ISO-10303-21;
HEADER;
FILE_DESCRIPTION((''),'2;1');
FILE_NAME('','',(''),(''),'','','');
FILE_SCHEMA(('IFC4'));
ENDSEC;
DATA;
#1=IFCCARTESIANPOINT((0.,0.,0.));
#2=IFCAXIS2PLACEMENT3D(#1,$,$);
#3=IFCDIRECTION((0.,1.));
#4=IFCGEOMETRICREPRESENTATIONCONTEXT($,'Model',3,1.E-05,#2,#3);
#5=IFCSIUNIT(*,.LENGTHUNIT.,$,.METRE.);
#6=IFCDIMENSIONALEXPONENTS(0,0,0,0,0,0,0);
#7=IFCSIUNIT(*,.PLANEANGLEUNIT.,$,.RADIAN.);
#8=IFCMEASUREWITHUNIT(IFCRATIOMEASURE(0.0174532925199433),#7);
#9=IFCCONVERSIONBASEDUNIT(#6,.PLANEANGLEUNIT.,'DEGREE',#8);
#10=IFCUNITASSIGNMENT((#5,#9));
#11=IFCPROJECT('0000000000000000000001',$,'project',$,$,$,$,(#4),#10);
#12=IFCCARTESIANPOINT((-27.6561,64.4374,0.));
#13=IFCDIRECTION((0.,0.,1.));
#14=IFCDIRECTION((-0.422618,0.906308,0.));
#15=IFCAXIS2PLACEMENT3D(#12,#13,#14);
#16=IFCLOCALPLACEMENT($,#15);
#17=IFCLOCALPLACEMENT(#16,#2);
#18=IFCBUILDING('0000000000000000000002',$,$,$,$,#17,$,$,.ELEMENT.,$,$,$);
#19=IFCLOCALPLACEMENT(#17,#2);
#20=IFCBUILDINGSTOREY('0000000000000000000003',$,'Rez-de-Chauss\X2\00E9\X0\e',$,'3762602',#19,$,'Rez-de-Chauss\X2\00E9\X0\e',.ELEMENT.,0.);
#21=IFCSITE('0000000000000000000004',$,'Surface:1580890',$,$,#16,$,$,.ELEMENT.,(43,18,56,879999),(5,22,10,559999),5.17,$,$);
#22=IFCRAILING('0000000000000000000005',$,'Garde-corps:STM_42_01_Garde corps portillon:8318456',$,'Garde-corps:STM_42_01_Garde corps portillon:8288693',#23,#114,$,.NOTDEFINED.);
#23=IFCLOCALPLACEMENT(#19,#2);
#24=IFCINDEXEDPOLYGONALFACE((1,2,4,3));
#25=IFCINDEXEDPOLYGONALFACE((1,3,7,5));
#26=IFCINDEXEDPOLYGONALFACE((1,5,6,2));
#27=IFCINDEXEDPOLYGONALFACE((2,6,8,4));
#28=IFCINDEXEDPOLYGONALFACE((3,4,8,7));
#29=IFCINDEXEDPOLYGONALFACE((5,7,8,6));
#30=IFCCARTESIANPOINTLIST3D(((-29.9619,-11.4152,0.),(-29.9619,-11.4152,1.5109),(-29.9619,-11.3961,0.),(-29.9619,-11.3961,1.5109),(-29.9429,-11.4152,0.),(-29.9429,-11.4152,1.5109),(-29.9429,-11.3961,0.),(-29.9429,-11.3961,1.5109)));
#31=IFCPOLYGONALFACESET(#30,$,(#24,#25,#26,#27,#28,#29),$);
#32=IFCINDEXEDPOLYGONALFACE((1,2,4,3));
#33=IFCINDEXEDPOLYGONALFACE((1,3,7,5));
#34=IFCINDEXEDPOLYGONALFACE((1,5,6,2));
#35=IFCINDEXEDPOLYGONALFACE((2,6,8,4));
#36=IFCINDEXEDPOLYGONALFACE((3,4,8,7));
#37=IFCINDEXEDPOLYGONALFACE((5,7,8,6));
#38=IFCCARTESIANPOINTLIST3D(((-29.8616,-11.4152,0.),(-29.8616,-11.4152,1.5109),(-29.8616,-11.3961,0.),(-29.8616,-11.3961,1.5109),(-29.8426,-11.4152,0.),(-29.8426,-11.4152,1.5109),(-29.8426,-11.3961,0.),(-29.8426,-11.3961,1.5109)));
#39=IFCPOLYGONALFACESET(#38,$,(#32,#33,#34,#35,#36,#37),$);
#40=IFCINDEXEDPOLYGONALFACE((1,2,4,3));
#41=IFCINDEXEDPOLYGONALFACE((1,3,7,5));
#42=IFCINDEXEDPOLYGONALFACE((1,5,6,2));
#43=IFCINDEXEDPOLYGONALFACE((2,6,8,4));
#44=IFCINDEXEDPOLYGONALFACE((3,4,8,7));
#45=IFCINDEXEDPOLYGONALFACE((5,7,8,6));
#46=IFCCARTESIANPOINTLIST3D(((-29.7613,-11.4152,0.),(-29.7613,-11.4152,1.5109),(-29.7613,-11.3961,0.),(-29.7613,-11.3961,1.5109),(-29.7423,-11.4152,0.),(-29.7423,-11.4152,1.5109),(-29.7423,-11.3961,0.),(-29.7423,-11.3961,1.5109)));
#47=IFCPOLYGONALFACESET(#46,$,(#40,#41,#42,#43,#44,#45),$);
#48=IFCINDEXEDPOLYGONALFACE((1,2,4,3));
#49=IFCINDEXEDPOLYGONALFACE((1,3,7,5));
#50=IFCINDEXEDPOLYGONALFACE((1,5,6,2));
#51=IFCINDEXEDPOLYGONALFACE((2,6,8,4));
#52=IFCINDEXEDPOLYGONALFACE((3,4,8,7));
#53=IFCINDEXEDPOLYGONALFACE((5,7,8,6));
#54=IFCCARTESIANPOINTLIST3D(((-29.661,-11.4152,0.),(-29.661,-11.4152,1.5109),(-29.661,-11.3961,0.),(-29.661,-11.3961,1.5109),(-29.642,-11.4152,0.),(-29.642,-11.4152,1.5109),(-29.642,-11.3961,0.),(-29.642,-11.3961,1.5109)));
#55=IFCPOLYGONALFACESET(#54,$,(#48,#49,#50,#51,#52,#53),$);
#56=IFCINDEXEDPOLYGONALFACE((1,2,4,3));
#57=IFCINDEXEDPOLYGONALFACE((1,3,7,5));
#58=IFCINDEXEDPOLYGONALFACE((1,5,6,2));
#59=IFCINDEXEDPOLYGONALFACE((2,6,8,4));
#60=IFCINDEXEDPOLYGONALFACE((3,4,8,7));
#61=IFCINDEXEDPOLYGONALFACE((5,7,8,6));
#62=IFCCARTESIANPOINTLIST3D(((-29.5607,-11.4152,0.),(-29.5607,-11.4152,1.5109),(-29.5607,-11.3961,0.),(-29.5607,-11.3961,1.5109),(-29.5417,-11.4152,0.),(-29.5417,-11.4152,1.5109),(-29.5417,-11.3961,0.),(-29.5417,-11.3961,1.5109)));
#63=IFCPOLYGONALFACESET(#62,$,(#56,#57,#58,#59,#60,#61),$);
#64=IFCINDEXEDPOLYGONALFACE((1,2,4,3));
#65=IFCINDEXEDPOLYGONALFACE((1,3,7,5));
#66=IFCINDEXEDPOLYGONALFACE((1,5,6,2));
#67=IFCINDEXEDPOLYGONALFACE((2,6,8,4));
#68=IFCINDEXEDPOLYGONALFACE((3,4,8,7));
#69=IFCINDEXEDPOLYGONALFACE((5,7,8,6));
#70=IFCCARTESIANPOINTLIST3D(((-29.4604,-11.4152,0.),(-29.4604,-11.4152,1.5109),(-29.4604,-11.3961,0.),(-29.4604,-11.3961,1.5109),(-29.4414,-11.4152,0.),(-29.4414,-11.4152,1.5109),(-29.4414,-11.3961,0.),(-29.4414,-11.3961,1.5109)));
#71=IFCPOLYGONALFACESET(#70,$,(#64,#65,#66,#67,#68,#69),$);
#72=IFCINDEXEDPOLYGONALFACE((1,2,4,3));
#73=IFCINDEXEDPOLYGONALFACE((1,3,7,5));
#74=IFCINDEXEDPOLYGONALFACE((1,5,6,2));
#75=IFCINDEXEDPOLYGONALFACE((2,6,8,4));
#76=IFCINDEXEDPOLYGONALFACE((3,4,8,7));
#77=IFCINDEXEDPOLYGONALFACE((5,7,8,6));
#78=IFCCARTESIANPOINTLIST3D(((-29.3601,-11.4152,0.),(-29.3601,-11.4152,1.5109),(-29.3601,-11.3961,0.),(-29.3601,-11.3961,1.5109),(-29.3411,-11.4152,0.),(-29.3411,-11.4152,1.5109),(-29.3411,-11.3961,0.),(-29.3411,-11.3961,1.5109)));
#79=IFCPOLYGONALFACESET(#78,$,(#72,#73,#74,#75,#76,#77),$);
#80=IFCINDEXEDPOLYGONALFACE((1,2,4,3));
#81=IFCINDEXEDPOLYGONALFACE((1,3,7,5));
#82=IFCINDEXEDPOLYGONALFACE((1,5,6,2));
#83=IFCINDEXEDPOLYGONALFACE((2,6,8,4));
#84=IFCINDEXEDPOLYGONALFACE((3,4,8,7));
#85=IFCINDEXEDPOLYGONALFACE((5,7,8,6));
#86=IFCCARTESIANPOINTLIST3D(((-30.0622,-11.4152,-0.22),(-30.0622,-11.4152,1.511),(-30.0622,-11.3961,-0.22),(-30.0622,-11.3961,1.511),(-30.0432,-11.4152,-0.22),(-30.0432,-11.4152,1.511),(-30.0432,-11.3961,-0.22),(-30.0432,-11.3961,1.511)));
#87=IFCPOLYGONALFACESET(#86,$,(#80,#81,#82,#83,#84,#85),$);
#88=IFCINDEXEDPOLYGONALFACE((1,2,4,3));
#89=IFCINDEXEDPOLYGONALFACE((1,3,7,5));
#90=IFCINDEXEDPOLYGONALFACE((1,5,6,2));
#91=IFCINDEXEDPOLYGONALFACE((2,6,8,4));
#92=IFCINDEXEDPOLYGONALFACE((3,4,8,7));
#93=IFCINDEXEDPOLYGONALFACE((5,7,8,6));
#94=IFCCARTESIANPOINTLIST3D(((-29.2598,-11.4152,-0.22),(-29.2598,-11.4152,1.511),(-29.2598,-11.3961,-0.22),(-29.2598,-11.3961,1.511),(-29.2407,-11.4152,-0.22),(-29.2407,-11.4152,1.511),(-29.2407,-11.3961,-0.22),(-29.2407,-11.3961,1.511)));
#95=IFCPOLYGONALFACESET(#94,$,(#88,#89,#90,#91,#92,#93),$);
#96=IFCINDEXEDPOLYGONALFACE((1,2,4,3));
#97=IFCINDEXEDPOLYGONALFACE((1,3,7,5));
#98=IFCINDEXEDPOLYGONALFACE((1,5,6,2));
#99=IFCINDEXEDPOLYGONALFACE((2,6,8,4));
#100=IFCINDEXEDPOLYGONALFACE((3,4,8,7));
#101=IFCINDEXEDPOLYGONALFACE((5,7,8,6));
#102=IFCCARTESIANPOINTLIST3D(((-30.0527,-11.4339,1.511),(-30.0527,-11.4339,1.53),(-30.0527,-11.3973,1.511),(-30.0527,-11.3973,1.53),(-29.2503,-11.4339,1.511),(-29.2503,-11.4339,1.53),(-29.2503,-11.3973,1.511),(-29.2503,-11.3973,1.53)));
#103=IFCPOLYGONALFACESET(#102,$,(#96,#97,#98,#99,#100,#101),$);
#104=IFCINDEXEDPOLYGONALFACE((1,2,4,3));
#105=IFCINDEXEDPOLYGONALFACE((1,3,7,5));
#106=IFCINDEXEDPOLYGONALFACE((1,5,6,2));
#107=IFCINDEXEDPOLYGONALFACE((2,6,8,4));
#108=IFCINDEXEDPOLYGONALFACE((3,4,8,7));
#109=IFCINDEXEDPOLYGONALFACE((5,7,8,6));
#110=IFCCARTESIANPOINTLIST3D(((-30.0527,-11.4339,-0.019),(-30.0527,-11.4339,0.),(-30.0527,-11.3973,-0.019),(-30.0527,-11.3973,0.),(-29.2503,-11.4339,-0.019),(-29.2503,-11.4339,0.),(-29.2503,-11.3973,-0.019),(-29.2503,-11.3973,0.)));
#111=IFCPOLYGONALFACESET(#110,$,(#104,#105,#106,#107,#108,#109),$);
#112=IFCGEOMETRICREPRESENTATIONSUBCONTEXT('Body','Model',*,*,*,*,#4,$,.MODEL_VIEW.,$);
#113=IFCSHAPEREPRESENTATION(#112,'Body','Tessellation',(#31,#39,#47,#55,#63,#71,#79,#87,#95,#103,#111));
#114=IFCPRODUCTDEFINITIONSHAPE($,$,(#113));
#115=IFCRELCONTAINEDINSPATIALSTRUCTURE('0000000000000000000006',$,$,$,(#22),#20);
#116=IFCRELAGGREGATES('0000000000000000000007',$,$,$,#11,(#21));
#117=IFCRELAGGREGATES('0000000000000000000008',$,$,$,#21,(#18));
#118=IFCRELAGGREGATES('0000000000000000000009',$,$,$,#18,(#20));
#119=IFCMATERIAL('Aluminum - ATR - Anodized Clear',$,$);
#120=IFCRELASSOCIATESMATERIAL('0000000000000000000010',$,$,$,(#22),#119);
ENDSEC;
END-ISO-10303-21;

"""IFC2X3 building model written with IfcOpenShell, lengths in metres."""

from ifc_helpers import new_model, entity, si_unit, converted_unit, direction, frame, frame_2d, origin, origin_2d_with_axis, place, context, subcontext, project, spatial, rectangle, extrude, material, element, save


model = new_model("IFC2X3")

# Units and contexts
model_context = context("Model", 3, precision=1e-05, world=origin(), true_north=direction((0.0, 1.0)))
body_context = subcontext(model_context, "Body", "Model", "MODEL_VIEW")
ifc_project = project(units=[si_unit("LENGTHUNIT", "METRE"), converted_unit("PLANEANGLEUNIT", "DEGREE", entity("IfcRatioMeasure", 0.0174532925199433), si_unit("PLANEANGLEUNIT", "RADIAN"), dimensions=[0, 0, 0, 0, 0, 0, 0])], contexts=[model_context])

# Site, building, storey
site_placement = place(None, frame((-27.6561, 64.4374, 0.0), z_axis=(0.0, 0.0, 1.0), x_axis=(-0.422618, 0.906308, 0.0)))
site = spatial("IfcSite", under=ifc_project, at=site_placement, Name="Surface:1580890", CompositionType="ELEMENT", RefLatitude=(43, 18, 56, 879999), RefLongitude=(5, 22, 10, 559999), RefElevation=5.17)
building_placement = place(site_placement, origin())
building = spatial("IfcBuilding", under=site, at=building_placement, CompositionType="ELEMENT")
storey_placement = place(building_placement, origin())
storey = spatial("IfcBuildingStorey", under=building, at=storey_placement, Name="Rez-de-Chaussée", ObjectType="3762602", LongName="Rez-de-Chaussée", CompositionType="ELEMENT", Elevation=0.0)

# Railing
ifc_material_1 = material(Name="Aluminum - ATR - Anodized Clear")
railing_1_placement = place(storey_placement, origin())
element("IfcRailing", 1, at=railing_1_placement, inside=storey, material=ifc_material_1, Name="Garde-corps:STM_42_01_Garde corps portillon:8318456", ObjectType="Garde-corps:STM_42_01_Garde corps portillon:8288693", PredefinedType="NOTDEFINED", context=body_context, shape_type="SweptSolid", body=[
    extrude(rectangle(XDim=0.0191, YDim=0.0191, at=origin_2d_with_axis()), frame((-29.9524, -11.4056, 0.0), z_axis=(0.0, 0.0, 1.0), x_axis=(-1.0, 0.0, 0.0)), (0.0, 0.0, 1.0), 1.5109),
    extrude(rectangle(XDim=0.0191, YDim=0.0191, at=origin_2d_with_axis()), frame((-29.8521, -11.4056, 0.0), z_axis=(0.0, 0.0, 1.0), x_axis=(-1.0, 0.0, 0.0)), (0.0, 0.0, 1.0), 1.5109),
    extrude(rectangle(XDim=0.0191, YDim=0.0191, at=origin_2d_with_axis()), frame((-29.7518, -11.4056, 0.0), z_axis=(0.0, 0.0, 1.0), x_axis=(-1.0, 0.0, 0.0)), (0.0, 0.0, 1.0), 1.5109),
    extrude(rectangle(XDim=0.0191, YDim=0.0191, at=origin_2d_with_axis()), frame((-29.6515, -11.4056, 0.0), z_axis=(0.0, 0.0, 1.0), x_axis=(-1.0, 0.0, 0.0)), (0.0, 0.0, 1.0), 1.5109),
    extrude(rectangle(XDim=0.0191, YDim=0.0191, at=origin_2d_with_axis()), frame((-29.5512, -11.4056, 0.0), z_axis=(0.0, 0.0, 1.0), x_axis=(-1.0, 0.0, 0.0)), (0.0, 0.0, 1.0), 1.5109),
    extrude(rectangle(XDim=0.0191, YDim=0.0191, at=origin_2d_with_axis()), frame((-29.4509, -11.4056, 0.0), z_axis=(0.0, 0.0, 1.0), x_axis=(-1.0, 0.0, 0.0)), (0.0, 0.0, 1.0), 1.5109),
    extrude(rectangle(XDim=0.0191, YDim=0.0191, at=origin_2d_with_axis()), frame((-29.3506, -11.4056, 0.0), z_axis=(0.0, 0.0, 1.0), x_axis=(-1.0, 0.0, 0.0)), (0.0, 0.0, 1.0), 1.5109),
    extrude(rectangle(XDim=0.0191, YDim=0.0191, at=origin_2d_with_axis()), frame((-30.0527, -11.4056, -0.22), z_axis=(0.0, 0.0, 1.0), x_axis=(-1.0, 0.0, 0.0)), (0.0, 0.0, 1.0), 1.7309),
    extrude(rectangle(XDim=0.0191, YDim=0.0191, at=origin_2d_with_axis()), frame((-29.2503, -11.4056, -0.22), z_axis=(0.0, 0.0, 1.0), x_axis=(-1.0, 0.0, 0.0)), (0.0, 0.0, 1.0), 1.7309),
    extrude(rectangle(XDim=0.8024, YDim=0.0366, at=frame_2d((0.0, 0.0), x_axis=(1.0, 0.0))), frame((-29.6515, -11.4156, 1.511), z_axis=(0.0, 0.0, 1.0), x_axis=(-1.0, 0.0, 0.0)), (0.0, 0.0, 1.0), 0.0191),
    extrude(rectangle(XDim=0.8024, YDim=0.0366, at=frame_2d((0.0, 0.0), x_axis=(1.0, 0.0))), frame((-29.6515, -11.4156, -0.019), z_axis=(0.0, 0.0, 1.0), x_axis=(-1.0, 0.0, 0.0)), (0.0, 0.0, 1.0), 0.0191),
])

save(model, "model.ifc")
